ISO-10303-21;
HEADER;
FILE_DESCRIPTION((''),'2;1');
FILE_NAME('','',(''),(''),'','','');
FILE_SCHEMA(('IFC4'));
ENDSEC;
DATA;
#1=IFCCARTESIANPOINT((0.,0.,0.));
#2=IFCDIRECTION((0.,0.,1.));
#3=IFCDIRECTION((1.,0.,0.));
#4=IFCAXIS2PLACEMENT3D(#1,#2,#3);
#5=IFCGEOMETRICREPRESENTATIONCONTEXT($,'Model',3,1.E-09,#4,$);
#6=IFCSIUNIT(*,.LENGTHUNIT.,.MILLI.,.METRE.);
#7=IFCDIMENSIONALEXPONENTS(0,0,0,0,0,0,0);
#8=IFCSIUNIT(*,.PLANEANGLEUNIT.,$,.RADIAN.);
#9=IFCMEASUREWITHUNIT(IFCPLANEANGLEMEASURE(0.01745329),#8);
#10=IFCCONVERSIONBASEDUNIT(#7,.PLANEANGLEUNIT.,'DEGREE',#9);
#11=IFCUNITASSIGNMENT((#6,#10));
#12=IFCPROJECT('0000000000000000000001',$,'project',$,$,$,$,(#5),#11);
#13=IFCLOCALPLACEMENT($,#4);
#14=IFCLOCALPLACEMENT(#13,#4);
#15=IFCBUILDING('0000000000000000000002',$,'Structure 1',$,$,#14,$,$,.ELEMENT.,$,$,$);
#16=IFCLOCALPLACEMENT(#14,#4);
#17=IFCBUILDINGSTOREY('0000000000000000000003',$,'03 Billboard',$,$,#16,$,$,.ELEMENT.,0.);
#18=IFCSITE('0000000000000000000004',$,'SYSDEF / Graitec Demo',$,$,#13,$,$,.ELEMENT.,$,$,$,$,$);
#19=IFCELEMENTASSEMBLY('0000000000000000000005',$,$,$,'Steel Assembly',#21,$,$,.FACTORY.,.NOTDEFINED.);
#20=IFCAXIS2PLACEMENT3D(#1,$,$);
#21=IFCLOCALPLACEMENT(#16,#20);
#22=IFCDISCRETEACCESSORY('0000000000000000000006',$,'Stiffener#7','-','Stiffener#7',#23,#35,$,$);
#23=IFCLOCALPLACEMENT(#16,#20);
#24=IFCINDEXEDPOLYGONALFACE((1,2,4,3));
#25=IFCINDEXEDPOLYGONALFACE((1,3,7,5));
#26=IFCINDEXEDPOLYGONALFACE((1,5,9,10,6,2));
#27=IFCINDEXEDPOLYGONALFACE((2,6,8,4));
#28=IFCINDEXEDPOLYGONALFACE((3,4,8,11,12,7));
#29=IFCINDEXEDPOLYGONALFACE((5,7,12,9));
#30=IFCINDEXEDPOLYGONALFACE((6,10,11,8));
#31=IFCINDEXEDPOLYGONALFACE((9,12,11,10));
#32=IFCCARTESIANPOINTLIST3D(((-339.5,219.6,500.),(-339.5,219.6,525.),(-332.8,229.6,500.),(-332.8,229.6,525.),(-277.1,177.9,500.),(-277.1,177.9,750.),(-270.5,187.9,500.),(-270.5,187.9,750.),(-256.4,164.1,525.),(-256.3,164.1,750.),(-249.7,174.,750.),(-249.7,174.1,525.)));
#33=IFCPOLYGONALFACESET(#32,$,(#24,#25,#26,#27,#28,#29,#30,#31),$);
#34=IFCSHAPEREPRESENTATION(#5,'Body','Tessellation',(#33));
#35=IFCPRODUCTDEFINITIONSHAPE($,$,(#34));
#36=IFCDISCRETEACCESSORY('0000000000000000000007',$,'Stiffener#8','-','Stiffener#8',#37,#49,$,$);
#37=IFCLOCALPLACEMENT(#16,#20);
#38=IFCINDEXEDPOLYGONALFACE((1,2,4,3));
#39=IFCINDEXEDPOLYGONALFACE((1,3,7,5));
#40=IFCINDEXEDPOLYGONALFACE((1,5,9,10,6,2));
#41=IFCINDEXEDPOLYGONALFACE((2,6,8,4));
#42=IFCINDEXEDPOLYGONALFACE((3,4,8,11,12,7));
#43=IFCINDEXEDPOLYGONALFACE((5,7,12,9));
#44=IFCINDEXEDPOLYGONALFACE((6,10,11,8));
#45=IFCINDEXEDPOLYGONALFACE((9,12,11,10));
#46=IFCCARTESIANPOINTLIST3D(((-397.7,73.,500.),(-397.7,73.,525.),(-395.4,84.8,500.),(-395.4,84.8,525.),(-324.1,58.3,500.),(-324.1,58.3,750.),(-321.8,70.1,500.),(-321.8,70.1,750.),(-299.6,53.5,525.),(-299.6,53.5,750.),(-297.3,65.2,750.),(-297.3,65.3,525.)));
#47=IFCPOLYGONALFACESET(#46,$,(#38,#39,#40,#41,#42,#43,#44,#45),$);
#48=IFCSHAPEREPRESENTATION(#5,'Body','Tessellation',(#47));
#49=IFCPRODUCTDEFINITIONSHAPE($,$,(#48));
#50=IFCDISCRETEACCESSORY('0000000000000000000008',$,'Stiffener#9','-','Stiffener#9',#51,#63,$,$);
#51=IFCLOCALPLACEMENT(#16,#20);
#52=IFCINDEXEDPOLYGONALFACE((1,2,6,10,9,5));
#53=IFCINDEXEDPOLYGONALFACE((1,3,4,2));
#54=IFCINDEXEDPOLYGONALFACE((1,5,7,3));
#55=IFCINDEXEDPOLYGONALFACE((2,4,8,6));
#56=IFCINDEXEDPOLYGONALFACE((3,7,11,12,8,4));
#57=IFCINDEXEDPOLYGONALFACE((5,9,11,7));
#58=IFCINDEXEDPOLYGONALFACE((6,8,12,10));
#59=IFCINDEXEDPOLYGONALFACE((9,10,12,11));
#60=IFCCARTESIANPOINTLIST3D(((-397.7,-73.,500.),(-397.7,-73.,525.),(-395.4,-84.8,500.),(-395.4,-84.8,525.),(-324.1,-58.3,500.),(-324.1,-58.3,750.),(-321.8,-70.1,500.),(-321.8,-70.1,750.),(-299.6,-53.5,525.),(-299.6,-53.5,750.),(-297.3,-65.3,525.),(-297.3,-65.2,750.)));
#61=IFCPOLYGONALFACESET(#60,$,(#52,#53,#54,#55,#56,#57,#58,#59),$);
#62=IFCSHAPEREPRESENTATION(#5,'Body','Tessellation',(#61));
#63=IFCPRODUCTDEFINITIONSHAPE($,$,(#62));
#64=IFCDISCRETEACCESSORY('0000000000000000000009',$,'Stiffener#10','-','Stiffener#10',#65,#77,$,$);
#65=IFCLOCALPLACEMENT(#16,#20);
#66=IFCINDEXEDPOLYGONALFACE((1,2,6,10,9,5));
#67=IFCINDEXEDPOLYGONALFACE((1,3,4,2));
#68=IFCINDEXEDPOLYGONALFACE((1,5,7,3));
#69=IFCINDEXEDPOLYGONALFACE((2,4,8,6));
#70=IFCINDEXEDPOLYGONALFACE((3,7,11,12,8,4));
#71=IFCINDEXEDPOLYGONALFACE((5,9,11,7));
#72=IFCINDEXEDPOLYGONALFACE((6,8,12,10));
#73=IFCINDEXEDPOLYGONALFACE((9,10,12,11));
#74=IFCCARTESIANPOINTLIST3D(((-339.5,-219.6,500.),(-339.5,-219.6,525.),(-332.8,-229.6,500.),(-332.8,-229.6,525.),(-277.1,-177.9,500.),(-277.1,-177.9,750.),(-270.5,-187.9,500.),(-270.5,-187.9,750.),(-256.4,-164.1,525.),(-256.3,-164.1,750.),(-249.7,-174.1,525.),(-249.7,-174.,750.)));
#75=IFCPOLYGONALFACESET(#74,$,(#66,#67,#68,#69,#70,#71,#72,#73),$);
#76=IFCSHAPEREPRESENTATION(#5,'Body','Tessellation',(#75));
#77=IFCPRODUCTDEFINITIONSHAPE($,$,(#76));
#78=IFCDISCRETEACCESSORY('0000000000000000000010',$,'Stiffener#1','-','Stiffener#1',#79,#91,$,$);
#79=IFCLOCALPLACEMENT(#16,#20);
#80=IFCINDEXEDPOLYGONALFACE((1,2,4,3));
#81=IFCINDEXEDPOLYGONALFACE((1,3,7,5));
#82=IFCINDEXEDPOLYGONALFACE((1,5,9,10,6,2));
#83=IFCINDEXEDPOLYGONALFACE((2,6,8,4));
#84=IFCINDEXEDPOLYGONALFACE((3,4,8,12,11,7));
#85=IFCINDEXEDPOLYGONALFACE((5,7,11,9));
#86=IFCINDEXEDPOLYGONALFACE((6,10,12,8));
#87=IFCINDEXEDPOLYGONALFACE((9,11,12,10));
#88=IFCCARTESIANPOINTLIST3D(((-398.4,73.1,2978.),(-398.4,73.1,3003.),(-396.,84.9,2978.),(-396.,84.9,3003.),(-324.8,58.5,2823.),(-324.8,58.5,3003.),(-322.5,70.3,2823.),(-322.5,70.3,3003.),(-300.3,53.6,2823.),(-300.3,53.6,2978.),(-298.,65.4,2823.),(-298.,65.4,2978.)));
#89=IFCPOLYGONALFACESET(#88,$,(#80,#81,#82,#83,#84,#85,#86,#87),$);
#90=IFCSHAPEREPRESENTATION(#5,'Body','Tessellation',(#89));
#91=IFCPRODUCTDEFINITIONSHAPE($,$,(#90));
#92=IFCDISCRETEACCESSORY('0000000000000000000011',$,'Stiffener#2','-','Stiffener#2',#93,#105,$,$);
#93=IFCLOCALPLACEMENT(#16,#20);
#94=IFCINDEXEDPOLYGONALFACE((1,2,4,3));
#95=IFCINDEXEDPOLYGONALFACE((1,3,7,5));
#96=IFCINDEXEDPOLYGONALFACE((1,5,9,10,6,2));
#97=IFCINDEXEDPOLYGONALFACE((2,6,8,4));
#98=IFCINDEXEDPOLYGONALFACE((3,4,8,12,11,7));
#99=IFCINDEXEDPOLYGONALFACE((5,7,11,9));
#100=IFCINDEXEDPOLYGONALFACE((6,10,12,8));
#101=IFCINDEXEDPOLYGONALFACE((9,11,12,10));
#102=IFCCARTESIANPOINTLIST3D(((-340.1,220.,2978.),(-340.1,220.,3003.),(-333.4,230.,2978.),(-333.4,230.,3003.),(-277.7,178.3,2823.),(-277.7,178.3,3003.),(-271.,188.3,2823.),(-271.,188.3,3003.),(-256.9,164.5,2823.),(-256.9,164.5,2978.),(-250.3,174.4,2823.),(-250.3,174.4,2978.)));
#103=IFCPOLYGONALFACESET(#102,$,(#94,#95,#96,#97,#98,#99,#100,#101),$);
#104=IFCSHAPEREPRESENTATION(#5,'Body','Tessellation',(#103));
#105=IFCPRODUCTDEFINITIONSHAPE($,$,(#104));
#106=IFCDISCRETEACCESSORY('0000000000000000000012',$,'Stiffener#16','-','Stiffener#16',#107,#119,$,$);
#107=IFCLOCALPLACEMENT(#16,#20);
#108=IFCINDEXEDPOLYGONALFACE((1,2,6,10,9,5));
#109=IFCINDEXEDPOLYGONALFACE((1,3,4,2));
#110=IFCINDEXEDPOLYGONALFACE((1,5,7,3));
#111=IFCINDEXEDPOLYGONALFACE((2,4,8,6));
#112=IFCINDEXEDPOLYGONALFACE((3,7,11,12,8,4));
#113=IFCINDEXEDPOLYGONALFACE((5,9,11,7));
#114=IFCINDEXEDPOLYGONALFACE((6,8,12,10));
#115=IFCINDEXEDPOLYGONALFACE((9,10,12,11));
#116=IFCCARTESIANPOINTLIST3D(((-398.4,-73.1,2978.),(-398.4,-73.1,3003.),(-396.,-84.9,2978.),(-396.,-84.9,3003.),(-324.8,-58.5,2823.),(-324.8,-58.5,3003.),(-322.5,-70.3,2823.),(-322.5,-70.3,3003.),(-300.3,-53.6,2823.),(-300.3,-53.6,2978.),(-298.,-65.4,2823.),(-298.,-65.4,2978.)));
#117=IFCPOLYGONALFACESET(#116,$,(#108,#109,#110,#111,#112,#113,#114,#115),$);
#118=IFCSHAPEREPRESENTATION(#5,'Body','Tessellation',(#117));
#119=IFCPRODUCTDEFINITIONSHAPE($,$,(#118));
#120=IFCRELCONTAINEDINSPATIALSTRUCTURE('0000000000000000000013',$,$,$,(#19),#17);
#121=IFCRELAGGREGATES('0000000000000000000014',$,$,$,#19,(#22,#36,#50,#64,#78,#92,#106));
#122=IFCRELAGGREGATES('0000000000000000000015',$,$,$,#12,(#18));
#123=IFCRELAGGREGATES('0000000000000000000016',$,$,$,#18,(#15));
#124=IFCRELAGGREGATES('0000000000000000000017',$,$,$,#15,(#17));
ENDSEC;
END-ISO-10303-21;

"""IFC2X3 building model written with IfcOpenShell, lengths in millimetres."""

from ifc_helpers import new_model, entity, si_unit, converted_unit, frame, origin, origin_with_axes, place, context, project, spatial, polyline, outline, extrude, element, aggregate, save


model = new_model("IFC2X3")

# Units and contexts
model_context = context("Model", 3, precision=1e-09, world=origin_with_axes())
ifc_project = project(units=[si_unit("LENGTHUNIT", "METRE", prefix="MILLI"), converted_unit("PLANEANGLEUNIT", "DEGREE", entity("IfcPlaneAngleMeasure", 0.01745329), si_unit("PLANEANGLEUNIT", "RADIAN"), dimensions=[0, 0, 0, 0, 0, 0, 0])], contexts=[model_context])

# Site, building, storey
site_placement = place(None, origin_with_axes())
site = spatial("IfcSite", under=ifc_project, at=site_placement, Name="SYSDEF / Graitec Demo", CompositionType="ELEMENT")
building_placement = place(site_placement, origin_with_axes())
building = spatial("IfcBuilding", under=site, at=building_placement, Name="Structure 1", CompositionType="ELEMENT")
storey_placement = place(building_placement, origin_with_axes())
storey = spatial("IfcBuildingStorey", under=building, at=storey_placement, Name="03 Billboard", CompositionType="ELEMENT", Elevation=0.0)

# Element assembly, discrete accessories, openings
assembly_placement = place(None, frame((0.0, 0.0, 43.7), z_axis=(0.0, 0.0, -1.0), x_axis=(0.0, 1.0, 0.0)))
assembly = element("IfcElementAssembly", 1, at=assembly_placement, inside=storey, ObjectType="Steel Assembly", AssemblyPlace="FACTORY", PredefinedType="NOTDEFINED")
discrete_accessory_1_placement = place(assembly_placement, frame((174.0, -249.7, -456.3), z_axis=(-0.83147, -0.55557, 0.0), x_axis=(0.0, 0.0, -1.0)))
discrete_accessory_1 = element("IfcDiscreteAccessory", 2, at=discrete_accessory_1_placement, Name="Stiffener#7", Description="-", ObjectType="Stiffener#7", context=model_context, shape_type="SweptSolid", body=[
    extrude(outline(polyline([(0.0, 0.0), (250.0, 0.0), (250.0, 100.0), (0.0, 100.0), (0.0, 0.0)])), origin_with_axes(), (0.0, 0.0, 1.0), 12.0),
])
opening_1_placement = place(discrete_accessory_1_placement, frame((0.0, 0.0, 0.0), z_axis=(0.0, 0.0, 1.0), x_axis=(1.0, 0.0, 0.0)))
element("IfcOpeningElement", 3, at=opening_1_placement, cuts=discrete_accessory_1, ObjectType="Opening", context=model_context, shape_type="SweptSolid", body=[
    extrude(outline(polyline([(250.0, 100.0), (25.0, 100.0), (250.0, 25.0), (250.0, 100.0)])), origin(), (0.0, 0.0, 1.0), 12.0),
])
opening_2_placement = place(discrete_accessory_1_placement, frame((0.0, 0.0, 0.0), z_axis=(0.0, 0.0, 1.0), x_axis=(1.0, 0.0, 0.0)))
element("IfcOpeningElement", 4, at=opening_2_placement, cuts=discrete_accessory_1, ObjectType="Opening", context=model_context, shape_type="SweptSolid", body=[
    extrude(outline(polyline([(0.0, 0.0), (25.0, 0.0), (0.0, 25.0), (0.0, 0.0)])), origin(), (0.0, 0.0, 1.0), 12.0),
])
discrete_accessory_2_placement = place(assembly_placement, frame((65.2, -297.3, -456.3), z_axis=(-0.980785, -0.19509, 0.0), x_axis=(0.0, 0.0, -1.0)))
discrete_accessory_2 = element("IfcDiscreteAccessory", 5, at=discrete_accessory_2_placement, Name="Stiffener#8", Description="-", ObjectType="Stiffener#8", context=model_context, shape_type="SweptSolid", body=[
    extrude(outline(polyline([(0.0, 0.0), (250.0, 0.0), (250.0, 100.0), (0.0, 100.0), (0.0, 0.0)])), origin_with_axes(), (0.0, 0.0, 1.0), 12.0),
])
opening_3_placement = place(discrete_accessory_2_placement, frame((0.0, 0.0, 0.0), z_axis=(0.0, 0.0, 1.0), x_axis=(1.0, 0.0, 0.0)))
element("IfcOpeningElement", 6, at=opening_3_placement, cuts=discrete_accessory_2, ObjectType="Opening", context=model_context, shape_type="SweptSolid", body=[
    extrude(outline(polyline([(250.0, 100.0), (25.0, 100.0), (250.0, 25.0), (250.0, 100.0)])), origin(), (0.0, 0.0, 1.0), 12.0),
])
opening_4_placement = place(discrete_accessory_2_placement, frame((0.0, 0.0, 0.0), z_axis=(0.0, 0.0, 1.0), x_axis=(1.0, 0.0, 0.0)))
element("IfcOpeningElement", 7, at=opening_4_placement, cuts=discrete_accessory_2, ObjectType="Opening", context=model_context, shape_type="SweptSolid", body=[
    extrude(outline(polyline([(0.0, 0.0), (25.0, 0.0), (0.0, 25.0), (0.0, 0.0)])), origin(), (0.0, 0.0, 1.0), 12.0),
])
discrete_accessory_3_placement = place(assembly_placement, frame((-53.5, -299.6, -456.3), z_axis=(-0.980785, 0.19509, 0.0), x_axis=(0.0, 0.0, -1.0)))
discrete_accessory_3 = element("IfcDiscreteAccessory", 8, at=discrete_accessory_3_placement, Name="Stiffener#9", Description="-", ObjectType="Stiffener#9", context=model_context, shape_type="SweptSolid", body=[
    extrude(outline(polyline([(0.0, 0.0), (250.0, 0.0), (250.0, 100.0), (0.0, 100.0), (0.0, 0.0)])), origin_with_axes(), (0.0, 0.0, 1.0), 12.0),
])
opening_5_placement = place(discrete_accessory_3_placement, frame((0.0, 0.0, 0.0), z_axis=(0.0, 0.0, 1.0), x_axis=(1.0, 0.0, 0.0)))
element("IfcOpeningElement", 9, at=opening_5_placement, cuts=discrete_accessory_3, ObjectType="Opening", context=model_context, shape_type="SweptSolid", body=[
    extrude(outline(polyline([(250.0, 100.0), (25.0, 100.0), (250.0, 25.0), (250.0, 100.0)])), origin(), (0.0, 0.0, 1.0), 12.0),
])
opening_6_placement = place(discrete_accessory_3_placement, frame((0.0, 0.0, 0.0), z_axis=(0.0, 0.0, 1.0), x_axis=(1.0, 0.0, 0.0)))
element("IfcOpeningElement", 10, at=opening_6_placement, cuts=discrete_accessory_3, ObjectType="Opening", context=model_context, shape_type="SweptSolid", body=[
    extrude(outline(polyline([(0.0, 0.0), (25.0, 0.0), (0.0, 25.0), (0.0, 0.0)])), origin(), (0.0, 0.0, 1.0), 12.0),
])
discrete_accessory_4_placement = place(assembly_placement, frame((-164.1, -256.3, -456.3), z_axis=(-0.83147, 0.55557, 0.0), x_axis=(0.0, 0.0, -1.0)))
discrete_accessory_4 = element("IfcDiscreteAccessory", 11, at=discrete_accessory_4_placement, Name="Stiffener#10", Description="-", ObjectType="Stiffener#10", context=model_context, shape_type="SweptSolid", body=[
    extrude(outline(polyline([(0.0, 0.0), (250.0, 0.0), (250.0, 100.0), (0.0, 100.0), (0.0, 0.0)])), origin_with_axes(), (0.0, 0.0, 1.0), 12.0),
])
opening_7_placement = place(discrete_accessory_4_placement, frame((0.0, 0.0, 0.0), z_axis=(0.0, 0.0, 1.0), x_axis=(1.0, 0.0, 0.0)))
element("IfcOpeningElement", 12, at=opening_7_placement, cuts=discrete_accessory_4, ObjectType="Opening", context=model_context, shape_type="SweptSolid", body=[
    extrude(outline(polyline([(250.0, 100.0), (25.0, 100.0), (250.0, 25.0), (250.0, 100.0)])), origin(), (0.0, 0.0, 1.0), 12.0),
])
opening_8_placement = place(discrete_accessory_4_placement, frame((0.0, 0.0, 0.0), z_axis=(0.0, 0.0, 1.0), x_axis=(1.0, 0.0, 0.0)))
element("IfcOpeningElement", 13, at=opening_8_placement, cuts=discrete_accessory_4, ObjectType="Opening", context=model_context, shape_type="SweptSolid", body=[
    extrude(outline(polyline([(0.0, 0.0), (25.0, 0.0), (0.0, 25.0), (0.0, 0.0)])), origin(), (0.0, 0.0, 1.0), 12.0),
])
discrete_accessory_5_placement = place(assembly_placement, frame((53.6, -300.3, -2959.3), z_axis=(0.980785, 0.19509, 0.0), x_axis=(0.0, 0.0, 1.0)))
discrete_accessory_5 = element("IfcDiscreteAccessory", 14, at=discrete_accessory_5_placement, Name="Stiffener#1", Description="-", ObjectType="Stiffener#1", context=model_context, shape_type="SweptSolid", body=[
    extrude(outline(polyline([(0.0, 0.0), (180.0, 0.0), (180.0, 100.0), (0.0, 100.0), (0.0, 0.0)])), origin_with_axes(), (0.0, 0.0, 1.0), 12.0),
])
opening_9_placement = place(discrete_accessory_5_placement, frame((0.0, 0.0, 0.0), z_axis=(0.0, 0.0, 1.0), x_axis=(1.0, 0.0, 0.0)))
element("IfcOpeningElement", 15, at=opening_9_placement, cuts=discrete_accessory_5, ObjectType="Opening", context=model_context, shape_type="SweptSolid", body=[
    extrude(outline(polyline([(180.0, 100.0), (25.0, 100.0), (180.0, 25.0), (180.0, 100.0)])), origin(), (0.0, 0.0, 1.0), 12.0),
])
opening_10_placement = place(discrete_accessory_5_placement, frame((0.0, 0.0, 0.0), z_axis=(0.0, 0.0, 1.0), x_axis=(1.0, 0.0, 0.0)))
element("IfcOpeningElement", 16, at=opening_10_placement, cuts=discrete_accessory_5, ObjectType="Opening", context=model_context, shape_type="SweptSolid", body=[
    extrude(outline(polyline([(0.0, 0.0), (25.0, 0.0), (0.0, 25.0), (0.0, 0.0)])), origin(), (0.0, 0.0, 1.0), 12.0),
])
discrete_accessory_6_placement = place(assembly_placement, frame((164.5, -256.9, -2959.3), z_axis=(0.83147, 0.55557, 0.0), x_axis=(0.0, 0.0, 1.0)))
discrete_accessory_6 = element("IfcDiscreteAccessory", 17, at=discrete_accessory_6_placement, Name="Stiffener#2", Description="-", ObjectType="Stiffener#2", context=model_context, shape_type="SweptSolid", body=[
    extrude(outline(polyline([(0.0, 0.0), (180.0, 0.0), (180.0, 100.0), (0.0, 100.0), (0.0, 0.0)])), origin_with_axes(), (0.0, 0.0, 1.0), 12.0),
])
opening_11_placement = place(discrete_accessory_6_placement, frame((0.0, 0.0, 0.0), z_axis=(0.0, 0.0, 1.0), x_axis=(1.0, 0.0, 0.0)))
element("IfcOpeningElement", 18, at=opening_11_placement, cuts=discrete_accessory_6, ObjectType="Opening", context=model_context, shape_type="SweptSolid", body=[
    extrude(outline(polyline([(180.0, 100.0), (25.0, 100.0), (180.0, 25.0), (180.0, 100.0)])), origin(), (0.0, 0.0, 1.0), 12.0),
])
opening_12_placement = place(discrete_accessory_6_placement, frame((0.0, 0.0, 0.0), z_axis=(0.0, 0.0, 1.0), x_axis=(1.0, 0.0, 0.0)))
element("IfcOpeningElement", 19, at=opening_12_placement, cuts=discrete_accessory_6, ObjectType="Opening", context=model_context, shape_type="SweptSolid", body=[
    extrude(outline(polyline([(0.0, 0.0), (25.0, 0.0), (0.0, 25.0), (0.0, 0.0)])), origin(), (0.0, 0.0, 1.0), 12.0),
])
discrete_accessory_7_placement = place(assembly_placement, frame((-65.4, -298.0, -2959.3), z_axis=(0.980785, -0.19509, 0.0), x_axis=(0.0, 0.0, 1.0)))
discrete_accessory_7 = element("IfcDiscreteAccessory", 20, at=discrete_accessory_7_placement, Name="Stiffener#16", Description="-", ObjectType="Stiffener#16", context=model_context, shape_type="SweptSolid", body=[
    extrude(outline(polyline([(0.0, 0.0), (180.0, 0.0), (180.0, 100.0), (0.0, 100.0), (0.0, 0.0)])), origin_with_axes(), (0.0, 0.0, 1.0), 12.0),
])
opening_13_placement = place(discrete_accessory_7_placement, frame((0.0, 0.0, 0.0), z_axis=(0.0, 0.0, 1.0), x_axis=(1.0, 0.0, 0.0)))
element("IfcOpeningElement", 21, at=opening_13_placement, cuts=discrete_accessory_7, ObjectType="Opening", context=model_context, shape_type="SweptSolid", body=[
    extrude(outline(polyline([(180.0, 100.0), (25.0, 100.0), (180.0, 25.0), (180.0, 100.0)])), origin(), (0.0, 0.0, 1.0), 12.0),
])
opening_14_placement = place(discrete_accessory_7_placement, frame((0.0, 0.0, 0.0), z_axis=(0.0, 0.0, 1.0), x_axis=(1.0, 0.0, 0.0)))
element("IfcOpeningElement", 22, at=opening_14_placement, cuts=discrete_accessory_7, ObjectType="Opening", context=model_context, shape_type="SweptSolid", body=[
    extrude(outline(polyline([(0.0, 0.0), (25.0, 0.0), (0.0, 25.0), (0.0, 0.0)])), origin(), (0.0, 0.0, 1.0), 12.0),
])
aggregate(assembly, [discrete_accessory_1, discrete_accessory_2, discrete_accessory_3, discrete_accessory_4, discrete_accessory_5, discrete_accessory_6, discrete_accessory_7])

save(model, "model.ifc")
